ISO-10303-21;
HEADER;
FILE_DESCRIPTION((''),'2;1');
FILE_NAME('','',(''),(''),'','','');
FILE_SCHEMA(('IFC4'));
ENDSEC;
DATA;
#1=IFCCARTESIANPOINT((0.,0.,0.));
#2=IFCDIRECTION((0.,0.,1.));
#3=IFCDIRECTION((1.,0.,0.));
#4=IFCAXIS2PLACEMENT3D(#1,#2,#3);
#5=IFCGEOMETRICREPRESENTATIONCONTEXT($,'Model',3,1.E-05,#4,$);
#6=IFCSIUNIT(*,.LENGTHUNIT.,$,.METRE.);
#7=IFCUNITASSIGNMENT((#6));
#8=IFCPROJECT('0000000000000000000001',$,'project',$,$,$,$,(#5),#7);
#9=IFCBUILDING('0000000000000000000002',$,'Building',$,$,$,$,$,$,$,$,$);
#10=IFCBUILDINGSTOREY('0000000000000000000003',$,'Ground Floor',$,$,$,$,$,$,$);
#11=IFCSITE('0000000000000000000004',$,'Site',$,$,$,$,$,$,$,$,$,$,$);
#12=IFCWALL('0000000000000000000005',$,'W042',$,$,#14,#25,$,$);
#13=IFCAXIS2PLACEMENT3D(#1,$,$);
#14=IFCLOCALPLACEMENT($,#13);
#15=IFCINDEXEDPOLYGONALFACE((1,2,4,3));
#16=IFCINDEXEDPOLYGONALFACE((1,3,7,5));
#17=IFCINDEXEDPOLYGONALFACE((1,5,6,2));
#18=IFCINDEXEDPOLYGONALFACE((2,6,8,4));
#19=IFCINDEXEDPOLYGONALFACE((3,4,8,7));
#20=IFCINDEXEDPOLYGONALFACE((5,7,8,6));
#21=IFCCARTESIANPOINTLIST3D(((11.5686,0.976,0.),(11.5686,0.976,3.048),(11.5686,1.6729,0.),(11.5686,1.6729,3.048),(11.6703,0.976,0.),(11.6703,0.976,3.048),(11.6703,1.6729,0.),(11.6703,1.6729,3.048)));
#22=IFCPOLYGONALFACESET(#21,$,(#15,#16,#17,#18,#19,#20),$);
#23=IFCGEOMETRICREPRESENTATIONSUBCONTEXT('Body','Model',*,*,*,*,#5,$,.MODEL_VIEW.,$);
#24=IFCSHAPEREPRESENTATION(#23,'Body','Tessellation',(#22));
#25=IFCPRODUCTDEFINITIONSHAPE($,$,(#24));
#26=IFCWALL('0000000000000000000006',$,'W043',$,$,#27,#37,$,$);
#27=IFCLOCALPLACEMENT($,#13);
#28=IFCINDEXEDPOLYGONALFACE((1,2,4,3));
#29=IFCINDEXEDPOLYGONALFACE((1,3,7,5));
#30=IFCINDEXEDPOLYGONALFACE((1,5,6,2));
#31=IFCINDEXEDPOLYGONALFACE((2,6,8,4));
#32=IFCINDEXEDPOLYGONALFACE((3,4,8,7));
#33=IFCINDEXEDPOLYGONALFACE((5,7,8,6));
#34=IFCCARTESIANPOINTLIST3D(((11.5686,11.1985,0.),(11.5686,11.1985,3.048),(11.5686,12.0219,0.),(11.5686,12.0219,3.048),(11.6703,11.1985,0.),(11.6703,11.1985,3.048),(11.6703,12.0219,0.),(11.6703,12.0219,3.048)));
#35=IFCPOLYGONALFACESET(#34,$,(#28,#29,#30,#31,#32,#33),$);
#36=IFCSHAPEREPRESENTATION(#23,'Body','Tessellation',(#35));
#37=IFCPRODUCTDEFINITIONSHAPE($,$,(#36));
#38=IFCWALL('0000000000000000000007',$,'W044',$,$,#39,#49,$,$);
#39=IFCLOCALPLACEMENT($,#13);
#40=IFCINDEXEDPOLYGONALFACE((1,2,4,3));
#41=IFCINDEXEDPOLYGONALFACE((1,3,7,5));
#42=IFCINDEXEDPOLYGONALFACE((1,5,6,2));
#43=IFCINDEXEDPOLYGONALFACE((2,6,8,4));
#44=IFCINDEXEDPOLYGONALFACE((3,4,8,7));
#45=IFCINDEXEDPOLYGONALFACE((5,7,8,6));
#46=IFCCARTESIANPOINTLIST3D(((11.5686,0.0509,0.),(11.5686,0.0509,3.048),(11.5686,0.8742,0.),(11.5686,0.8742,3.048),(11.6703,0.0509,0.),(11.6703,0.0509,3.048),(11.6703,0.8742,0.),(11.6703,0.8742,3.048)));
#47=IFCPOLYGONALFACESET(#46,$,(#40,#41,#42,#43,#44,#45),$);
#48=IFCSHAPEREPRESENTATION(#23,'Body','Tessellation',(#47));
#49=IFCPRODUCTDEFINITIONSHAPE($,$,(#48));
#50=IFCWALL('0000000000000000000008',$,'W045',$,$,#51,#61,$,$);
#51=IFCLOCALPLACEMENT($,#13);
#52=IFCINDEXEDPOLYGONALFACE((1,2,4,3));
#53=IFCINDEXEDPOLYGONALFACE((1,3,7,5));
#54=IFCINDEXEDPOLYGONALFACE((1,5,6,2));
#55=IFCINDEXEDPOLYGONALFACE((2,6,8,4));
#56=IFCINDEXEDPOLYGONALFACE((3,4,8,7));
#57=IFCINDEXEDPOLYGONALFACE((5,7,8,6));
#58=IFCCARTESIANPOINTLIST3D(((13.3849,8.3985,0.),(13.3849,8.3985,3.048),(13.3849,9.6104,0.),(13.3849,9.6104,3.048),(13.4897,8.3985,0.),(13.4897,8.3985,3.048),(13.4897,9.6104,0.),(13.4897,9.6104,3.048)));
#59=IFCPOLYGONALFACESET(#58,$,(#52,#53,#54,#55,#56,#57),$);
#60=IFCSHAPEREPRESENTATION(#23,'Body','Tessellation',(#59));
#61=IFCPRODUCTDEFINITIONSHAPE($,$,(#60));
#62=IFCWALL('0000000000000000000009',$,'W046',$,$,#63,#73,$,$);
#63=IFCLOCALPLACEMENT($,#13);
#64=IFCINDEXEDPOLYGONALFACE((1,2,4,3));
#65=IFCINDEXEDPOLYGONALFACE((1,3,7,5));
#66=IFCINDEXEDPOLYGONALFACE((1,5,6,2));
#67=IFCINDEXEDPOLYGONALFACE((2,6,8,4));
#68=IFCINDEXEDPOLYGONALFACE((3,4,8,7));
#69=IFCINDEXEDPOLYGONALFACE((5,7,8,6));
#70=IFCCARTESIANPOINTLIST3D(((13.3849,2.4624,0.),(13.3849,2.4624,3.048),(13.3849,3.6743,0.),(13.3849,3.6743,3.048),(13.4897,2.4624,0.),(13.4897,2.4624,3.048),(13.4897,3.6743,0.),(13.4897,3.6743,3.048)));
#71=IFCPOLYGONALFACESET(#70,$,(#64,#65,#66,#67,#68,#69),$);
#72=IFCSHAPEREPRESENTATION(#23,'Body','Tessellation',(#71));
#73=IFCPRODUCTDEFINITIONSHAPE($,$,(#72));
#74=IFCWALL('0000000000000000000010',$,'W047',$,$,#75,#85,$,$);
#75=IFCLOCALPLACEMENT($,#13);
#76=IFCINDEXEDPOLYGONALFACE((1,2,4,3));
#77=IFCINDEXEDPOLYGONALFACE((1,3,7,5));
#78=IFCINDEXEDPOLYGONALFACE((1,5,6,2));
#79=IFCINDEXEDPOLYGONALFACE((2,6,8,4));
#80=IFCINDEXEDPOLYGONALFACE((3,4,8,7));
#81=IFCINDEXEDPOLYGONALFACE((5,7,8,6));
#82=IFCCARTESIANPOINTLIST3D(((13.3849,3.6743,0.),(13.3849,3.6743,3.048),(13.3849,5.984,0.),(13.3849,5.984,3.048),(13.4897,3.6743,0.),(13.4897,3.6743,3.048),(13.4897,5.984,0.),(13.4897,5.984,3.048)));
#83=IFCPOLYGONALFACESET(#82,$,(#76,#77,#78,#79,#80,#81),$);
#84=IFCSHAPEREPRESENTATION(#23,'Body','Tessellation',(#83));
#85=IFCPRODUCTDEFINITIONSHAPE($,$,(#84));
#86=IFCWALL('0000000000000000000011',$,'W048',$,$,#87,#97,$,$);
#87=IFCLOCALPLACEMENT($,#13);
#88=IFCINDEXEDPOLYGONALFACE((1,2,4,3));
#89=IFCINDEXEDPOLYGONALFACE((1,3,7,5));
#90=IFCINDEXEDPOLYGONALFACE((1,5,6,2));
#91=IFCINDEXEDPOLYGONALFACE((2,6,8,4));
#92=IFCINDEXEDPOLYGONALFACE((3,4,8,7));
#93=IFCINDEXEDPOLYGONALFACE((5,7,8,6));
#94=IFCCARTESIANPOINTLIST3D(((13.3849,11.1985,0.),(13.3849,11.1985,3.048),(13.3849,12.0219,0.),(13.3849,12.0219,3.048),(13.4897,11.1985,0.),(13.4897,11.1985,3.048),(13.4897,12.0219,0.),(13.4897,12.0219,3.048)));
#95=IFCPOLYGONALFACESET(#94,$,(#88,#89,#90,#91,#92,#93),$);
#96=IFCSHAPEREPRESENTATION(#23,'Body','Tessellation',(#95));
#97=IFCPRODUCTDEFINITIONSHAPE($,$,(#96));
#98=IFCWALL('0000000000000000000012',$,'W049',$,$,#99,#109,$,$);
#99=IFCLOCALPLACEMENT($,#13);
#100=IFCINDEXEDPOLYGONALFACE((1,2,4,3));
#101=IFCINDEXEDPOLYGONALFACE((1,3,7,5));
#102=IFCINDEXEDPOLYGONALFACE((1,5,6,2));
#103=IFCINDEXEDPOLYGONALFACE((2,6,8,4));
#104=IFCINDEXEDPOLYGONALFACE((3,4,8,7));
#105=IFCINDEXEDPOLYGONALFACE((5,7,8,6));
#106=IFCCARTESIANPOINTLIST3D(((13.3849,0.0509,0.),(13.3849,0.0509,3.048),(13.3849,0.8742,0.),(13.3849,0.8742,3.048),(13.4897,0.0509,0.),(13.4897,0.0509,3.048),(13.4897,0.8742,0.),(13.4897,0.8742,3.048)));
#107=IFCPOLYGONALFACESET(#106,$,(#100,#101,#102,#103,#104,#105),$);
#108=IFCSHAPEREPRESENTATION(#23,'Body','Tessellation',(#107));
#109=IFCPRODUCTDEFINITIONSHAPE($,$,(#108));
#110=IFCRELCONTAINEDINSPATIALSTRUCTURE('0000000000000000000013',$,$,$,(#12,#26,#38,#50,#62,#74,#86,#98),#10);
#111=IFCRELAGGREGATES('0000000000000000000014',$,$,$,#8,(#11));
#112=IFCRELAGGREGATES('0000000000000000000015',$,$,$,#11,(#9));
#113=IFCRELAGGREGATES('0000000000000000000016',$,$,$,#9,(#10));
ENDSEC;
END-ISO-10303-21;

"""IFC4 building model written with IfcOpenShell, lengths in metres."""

from ifc_helpers import new_model, si_unit, frame, origin_with_axes, place, context, subcontext, project, spatial, line, indexed_curve, outline, extrude, element, save


model = new_model("IFC4")

# Units and contexts
model_context = context("Model", 3, precision=1e-05, world=origin_with_axes())
body_context = subcontext(model_context, "Body", "Model", "MODEL_VIEW")
ifc_project = project(units=[si_unit("LENGTHUNIT", "METRE")], contexts=[model_context])

# Site, building, storey
site = spatial("IfcSite", under=ifc_project, Name="Site")
building = spatial("IfcBuilding", under=site, Name="Building")
storey = spatial("IfcBuildingStorey", under=building, Name="Ground Floor")

# Walls
wall_1_placement = place(None, frame((11.6195, 0.976, 0.0), z_axis=(0.0, 0.0, 1.0), x_axis=(0.0, 1.0, 0.0)))
element("IfcWall", 1, at=wall_1_placement, inside=storey, Name="W042", context=body_context, shape_type="SweptSolid", body=[
    extrude(outline(indexed_curve([(0.0, -0.0509), (0.6969, -0.0509), (0.6969, 0.0509), (0.0, 0.0509)], segments=[line(1, 2, 3, 4, 1)])), origin_with_axes(), (0.0, 0.0, 1.0), 3.048),
])
wall_2_placement = place(None, frame((11.6195, 11.1985, 0.0), z_axis=(0.0, 0.0, 1.0), x_axis=(0.0, 1.0, 0.0)))
element("IfcWall", 2, at=wall_2_placement, inside=storey, Name="W043", context=body_context, shape_type="SweptSolid", body=[
    extrude(outline(indexed_curve([(0.0, -0.0509), (0.8234, -0.0509), (0.8234, 0.0509), (0.0, 0.0509)], segments=[line(1, 2, 3, 4, 1)])), origin_with_axes(), (0.0, 0.0, 1.0), 3.048),
])
wall_3_placement = place(None, frame((11.6195, 0.0509, 0.0), z_axis=(0.0, 0.0, 1.0), x_axis=(0.0, 1.0, 0.0)))
element("IfcWall", 3, at=wall_3_placement, inside=storey, Name="W044", context=body_context, shape_type="SweptSolid", body=[
    extrude(outline(indexed_curve([(0.0, -0.0509), (0.8234, -0.0509), (0.8234, 0.0509), (0.0, 0.0509)], segments=[line(1, 2, 3, 4, 1)])), origin_with_axes(), (0.0, 0.0, 1.0), 3.048),
])
wall_4_placement = place(None, frame((13.4373, 8.3985, 0.0), z_axis=(0.0, 0.0, 1.0), x_axis=(0.0, 1.0, 0.0)))
element("IfcWall", 4, at=wall_4_placement, inside=storey, Name="W045", context=body_context, shape_type="SweptSolid", body=[
    extrude(outline(indexed_curve([(0.0, -0.0524), (1.2119, -0.0524), (1.2119, 0.0524), (0.0, 0.0524)], segments=[line(1, 2, 3, 4, 1)])), origin_with_axes(), (0.0, 0.0, 1.0), 3.048),
])
wall_5_placement = place(None, frame((13.4373, 2.4624, 0.0), z_axis=(0.0, 0.0, 1.0), x_axis=(0.0, 1.0, 0.0)))
element("IfcWall", 5, at=wall_5_placement, inside=storey, Name="W046", context=body_context, shape_type="SweptSolid", body=[
    extrude(outline(indexed_curve([(0.0, -0.0524), (1.2119, -0.0524), (1.2119, 0.0524), (0.0, 0.0524)], segments=[line(1, 2, 3, 4, 1)])), origin_with_axes(), (0.0, 0.0, 1.0), 3.048),
])
wall_6_placement = place(None, frame((13.4373, 3.6743, 0.0), z_axis=(0.0, 0.0, 1.0), x_axis=(0.0, 1.0, 0.0)))
element("IfcWall", 6, at=wall_6_placement, inside=storey, Name="W047", context=body_context, shape_type="SweptSolid", body=[
    extrude(outline(indexed_curve([(0.0, -0.0524), (2.3097, -0.0524), (2.3097, 0.0524), (0.0, 0.0524)], segments=[line(1, 2, 3, 4, 1)])), origin_with_axes(), (0.0, 0.0, 1.0), 3.048),
])
wall_7_placement = place(None, frame((13.4373, 11.1985, 0.0), z_axis=(0.0, 0.0, 1.0), x_axis=(0.0, 1.0, 0.0)))
element("IfcWall", 7, at=wall_7_placement, inside=storey, Name="W048", context=body_context, shape_type="SweptSolid", body=[
    extrude(outline(indexed_curve([(0.0, -0.0524), (0.8234, -0.0524), (0.8234, 0.0524), (0.0, 0.0524)], segments=[line(1, 2, 3, 4, 1)])), origin_with_axes(), (0.0, 0.0, 1.0), 3.048),
])
wall_8_placement = place(None, frame((13.4373, 0.0509, 0.0), z_axis=(0.0, 0.0, 1.0), x_axis=(0.0, 1.0, 0.0)))
element("IfcWall", 8, at=wall_8_placement, inside=storey, Name="W049", context=body_context, shape_type="SweptSolid", body=[
    extrude(outline(indexed_curve([(0.0, -0.0524), (0.8234, -0.0524), (0.8234, 0.0524), (0.0, 0.0524)], segments=[line(1, 2, 3, 4, 1)])), origin_with_axes(), (0.0, 0.0, 1.0), 3.048),
])

save(model, "model.ifc")
